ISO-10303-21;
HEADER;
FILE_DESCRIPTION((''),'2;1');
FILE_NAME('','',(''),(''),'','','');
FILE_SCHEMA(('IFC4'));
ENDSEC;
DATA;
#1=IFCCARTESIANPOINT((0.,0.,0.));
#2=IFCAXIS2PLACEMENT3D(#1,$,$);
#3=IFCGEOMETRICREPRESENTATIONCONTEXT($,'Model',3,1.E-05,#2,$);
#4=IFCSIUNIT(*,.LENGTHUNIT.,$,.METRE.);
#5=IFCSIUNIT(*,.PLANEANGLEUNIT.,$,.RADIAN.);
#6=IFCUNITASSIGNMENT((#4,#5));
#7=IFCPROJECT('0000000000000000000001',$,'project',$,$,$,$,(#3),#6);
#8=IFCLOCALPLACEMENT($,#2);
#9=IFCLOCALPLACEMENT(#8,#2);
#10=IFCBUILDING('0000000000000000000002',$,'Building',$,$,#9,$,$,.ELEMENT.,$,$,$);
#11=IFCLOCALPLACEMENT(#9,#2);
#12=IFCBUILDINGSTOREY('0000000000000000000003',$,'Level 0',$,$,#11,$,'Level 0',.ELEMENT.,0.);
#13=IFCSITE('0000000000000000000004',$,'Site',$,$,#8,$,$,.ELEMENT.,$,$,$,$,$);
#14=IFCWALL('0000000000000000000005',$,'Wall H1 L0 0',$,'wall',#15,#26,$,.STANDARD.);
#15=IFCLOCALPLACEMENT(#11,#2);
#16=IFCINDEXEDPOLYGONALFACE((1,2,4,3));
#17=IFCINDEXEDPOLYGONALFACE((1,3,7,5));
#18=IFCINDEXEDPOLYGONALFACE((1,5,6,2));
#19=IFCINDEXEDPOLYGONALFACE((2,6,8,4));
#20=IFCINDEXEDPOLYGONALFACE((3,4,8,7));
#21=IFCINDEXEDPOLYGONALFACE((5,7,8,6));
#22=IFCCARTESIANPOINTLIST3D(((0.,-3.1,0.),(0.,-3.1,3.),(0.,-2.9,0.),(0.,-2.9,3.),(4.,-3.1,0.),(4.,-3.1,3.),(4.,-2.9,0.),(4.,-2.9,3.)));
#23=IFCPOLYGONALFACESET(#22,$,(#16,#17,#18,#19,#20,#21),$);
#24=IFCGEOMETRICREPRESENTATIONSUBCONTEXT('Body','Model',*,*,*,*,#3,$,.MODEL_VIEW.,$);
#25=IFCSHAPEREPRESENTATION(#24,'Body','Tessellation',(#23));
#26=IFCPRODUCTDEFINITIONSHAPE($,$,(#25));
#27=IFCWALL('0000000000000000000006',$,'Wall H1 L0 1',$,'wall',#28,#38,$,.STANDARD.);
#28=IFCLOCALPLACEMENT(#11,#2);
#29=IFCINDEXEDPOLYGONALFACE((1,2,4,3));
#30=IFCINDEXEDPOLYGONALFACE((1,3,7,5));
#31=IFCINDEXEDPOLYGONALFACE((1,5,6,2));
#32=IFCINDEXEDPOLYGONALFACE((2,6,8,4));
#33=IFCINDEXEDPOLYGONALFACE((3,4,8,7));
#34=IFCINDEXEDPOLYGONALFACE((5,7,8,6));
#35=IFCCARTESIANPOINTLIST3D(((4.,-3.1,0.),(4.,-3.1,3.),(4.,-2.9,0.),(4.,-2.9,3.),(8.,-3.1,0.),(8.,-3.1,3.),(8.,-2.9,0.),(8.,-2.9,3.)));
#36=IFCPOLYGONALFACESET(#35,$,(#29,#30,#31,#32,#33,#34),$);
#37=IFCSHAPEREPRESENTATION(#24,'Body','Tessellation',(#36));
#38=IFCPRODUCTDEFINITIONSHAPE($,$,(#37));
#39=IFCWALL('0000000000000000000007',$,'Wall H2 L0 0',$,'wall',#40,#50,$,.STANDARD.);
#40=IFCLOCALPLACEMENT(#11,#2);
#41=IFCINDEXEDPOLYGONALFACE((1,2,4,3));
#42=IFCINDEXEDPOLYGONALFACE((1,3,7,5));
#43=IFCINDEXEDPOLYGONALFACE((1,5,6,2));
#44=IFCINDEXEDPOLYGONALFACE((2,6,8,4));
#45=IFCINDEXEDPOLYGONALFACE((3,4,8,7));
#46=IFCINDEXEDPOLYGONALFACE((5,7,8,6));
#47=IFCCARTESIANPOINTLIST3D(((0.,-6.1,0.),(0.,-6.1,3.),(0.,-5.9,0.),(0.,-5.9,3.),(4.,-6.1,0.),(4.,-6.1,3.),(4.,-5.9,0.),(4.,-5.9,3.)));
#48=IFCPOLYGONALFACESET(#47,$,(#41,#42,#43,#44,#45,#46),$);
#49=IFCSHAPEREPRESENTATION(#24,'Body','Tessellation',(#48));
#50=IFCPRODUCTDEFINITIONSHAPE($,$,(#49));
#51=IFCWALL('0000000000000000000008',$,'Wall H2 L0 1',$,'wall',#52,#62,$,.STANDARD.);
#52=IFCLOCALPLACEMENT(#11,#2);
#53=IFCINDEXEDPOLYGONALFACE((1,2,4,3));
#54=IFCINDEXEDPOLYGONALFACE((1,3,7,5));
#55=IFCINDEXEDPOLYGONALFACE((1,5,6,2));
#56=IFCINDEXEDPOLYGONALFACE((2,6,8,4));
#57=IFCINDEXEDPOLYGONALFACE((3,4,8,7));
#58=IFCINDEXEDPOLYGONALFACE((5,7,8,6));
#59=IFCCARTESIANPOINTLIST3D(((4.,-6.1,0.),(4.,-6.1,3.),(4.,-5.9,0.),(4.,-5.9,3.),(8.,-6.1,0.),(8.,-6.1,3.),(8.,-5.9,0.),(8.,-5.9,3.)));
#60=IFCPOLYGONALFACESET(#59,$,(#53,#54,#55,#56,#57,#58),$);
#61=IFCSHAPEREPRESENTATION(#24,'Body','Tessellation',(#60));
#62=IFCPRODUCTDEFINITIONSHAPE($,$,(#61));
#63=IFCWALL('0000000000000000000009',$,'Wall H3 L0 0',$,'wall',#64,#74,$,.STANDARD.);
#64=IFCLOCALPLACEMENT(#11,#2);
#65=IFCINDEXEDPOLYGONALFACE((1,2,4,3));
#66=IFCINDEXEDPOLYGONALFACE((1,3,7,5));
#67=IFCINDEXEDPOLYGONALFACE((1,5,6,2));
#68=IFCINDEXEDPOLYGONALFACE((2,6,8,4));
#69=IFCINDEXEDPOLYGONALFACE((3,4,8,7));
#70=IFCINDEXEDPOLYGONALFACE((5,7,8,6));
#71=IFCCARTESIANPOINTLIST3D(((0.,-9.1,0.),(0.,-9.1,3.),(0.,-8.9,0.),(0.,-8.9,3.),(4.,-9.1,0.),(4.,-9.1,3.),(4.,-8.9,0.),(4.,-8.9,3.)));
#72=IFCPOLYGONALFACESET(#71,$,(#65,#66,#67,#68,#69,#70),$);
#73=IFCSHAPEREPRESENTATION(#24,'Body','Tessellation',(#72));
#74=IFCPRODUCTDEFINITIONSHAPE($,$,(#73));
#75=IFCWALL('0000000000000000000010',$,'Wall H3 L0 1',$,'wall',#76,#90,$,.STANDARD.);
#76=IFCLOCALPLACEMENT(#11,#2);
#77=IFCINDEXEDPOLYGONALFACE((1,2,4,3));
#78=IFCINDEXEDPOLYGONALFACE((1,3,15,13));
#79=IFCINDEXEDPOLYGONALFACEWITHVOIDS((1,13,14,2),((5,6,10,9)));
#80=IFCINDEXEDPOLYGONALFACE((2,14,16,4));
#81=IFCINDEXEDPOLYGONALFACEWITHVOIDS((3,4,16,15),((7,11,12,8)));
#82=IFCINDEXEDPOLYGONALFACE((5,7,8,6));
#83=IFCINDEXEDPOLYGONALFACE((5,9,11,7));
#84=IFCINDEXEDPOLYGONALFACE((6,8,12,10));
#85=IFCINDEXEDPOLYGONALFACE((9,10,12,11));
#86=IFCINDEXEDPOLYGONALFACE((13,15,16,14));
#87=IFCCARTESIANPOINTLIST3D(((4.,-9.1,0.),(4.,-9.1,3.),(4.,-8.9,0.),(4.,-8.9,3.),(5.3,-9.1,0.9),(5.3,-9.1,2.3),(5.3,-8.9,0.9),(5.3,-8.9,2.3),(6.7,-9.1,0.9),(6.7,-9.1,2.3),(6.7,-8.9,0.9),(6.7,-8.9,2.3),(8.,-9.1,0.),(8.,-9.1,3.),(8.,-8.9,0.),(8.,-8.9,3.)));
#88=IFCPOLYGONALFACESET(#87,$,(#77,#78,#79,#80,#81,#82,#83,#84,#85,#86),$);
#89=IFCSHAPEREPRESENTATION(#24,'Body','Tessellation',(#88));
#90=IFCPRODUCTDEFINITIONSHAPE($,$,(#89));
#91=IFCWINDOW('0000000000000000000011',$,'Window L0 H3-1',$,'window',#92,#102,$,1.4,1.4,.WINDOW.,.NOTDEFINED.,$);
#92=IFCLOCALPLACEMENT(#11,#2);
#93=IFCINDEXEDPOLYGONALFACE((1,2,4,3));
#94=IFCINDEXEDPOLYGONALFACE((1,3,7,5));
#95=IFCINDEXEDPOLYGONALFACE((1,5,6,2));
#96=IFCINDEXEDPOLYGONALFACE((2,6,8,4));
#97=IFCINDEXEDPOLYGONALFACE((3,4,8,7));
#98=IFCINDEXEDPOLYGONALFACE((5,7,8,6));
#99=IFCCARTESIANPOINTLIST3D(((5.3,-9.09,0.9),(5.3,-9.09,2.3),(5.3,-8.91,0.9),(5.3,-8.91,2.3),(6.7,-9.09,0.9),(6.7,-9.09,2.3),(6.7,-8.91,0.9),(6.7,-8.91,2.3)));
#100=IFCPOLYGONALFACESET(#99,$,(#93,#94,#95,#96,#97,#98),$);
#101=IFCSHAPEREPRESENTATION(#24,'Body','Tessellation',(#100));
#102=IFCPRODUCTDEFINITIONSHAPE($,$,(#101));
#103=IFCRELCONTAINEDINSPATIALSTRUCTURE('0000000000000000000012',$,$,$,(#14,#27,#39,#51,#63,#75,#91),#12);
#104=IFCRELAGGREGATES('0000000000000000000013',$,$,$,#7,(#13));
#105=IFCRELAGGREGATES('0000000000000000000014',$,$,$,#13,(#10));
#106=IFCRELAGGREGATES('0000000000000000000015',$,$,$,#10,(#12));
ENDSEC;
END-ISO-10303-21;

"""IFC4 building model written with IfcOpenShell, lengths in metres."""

from ifc_helpers import new_model, si_unit, frame, frame_2d, origin, origin_2d, place, context, subcontext, project, spatial, rectangle, extrude, element, fill, save


model = new_model("IFC4")

# Units and contexts
model_context = context("Model", 3, precision=1e-05, world=origin())
body_context = subcontext(model_context, "Body", "Model", "MODEL_VIEW")
ifc_project = project(units=[si_unit("LENGTHUNIT", "METRE"), si_unit("PLANEANGLEUNIT", "RADIAN")], contexts=[model_context])

# Site, building, storey
site_placement = place(None, origin())
site = spatial("IfcSite", under=ifc_project, at=site_placement, Name="Site", CompositionType="ELEMENT")
building_placement = place(site_placement, origin())
building = spatial("IfcBuilding", under=site, at=building_placement, Name="Building", CompositionType="ELEMENT")
storey_placement = place(building_placement, origin())
storey = spatial("IfcBuildingStorey", under=building, at=storey_placement, Name="Level 0", LongName="Level 0", CompositionType="ELEMENT", Elevation=0.0)

# Walls
for number, where, z_axis, x_axis, name in (
    (1, (0.0, -3.0, 0.0), (0.0, 0.0, 1.0), (1.0, 0.0, 0.0), "Wall H1 L0 0"),
    (2, (4.0, -3.0, 0.0), (0.0, 0.0, 1.0), (1.0, 0.0, 0.0), "Wall H1 L0 1"),
    (3, (0.0, -6.0, 0.0), (0.0, 0.0, 1.0), (1.0, 0.0, 0.0), "Wall H2 L0 0"),
    (4, (4.0, -6.0, 0.0), (0.0, 0.0, 1.0), (1.0, 0.0, 0.0), "Wall H2 L0 1"),
    (5, (0.0, -9.0, 0.0), (0.0, 0.0, 1.0), (1.0, 0.0, 0.0), "Wall H3 L0 0"),
):
    element("IfcWall", number, at=place(storey_placement, frame(where, z_axis=z_axis, x_axis=x_axis)), inside=storey, Name=name, ObjectType="wall", PredefinedType="STANDARD", context=body_context, shape_type="SweptSolid", body=[
        extrude(rectangle(XDim=4.0, YDim=0.2, at=frame_2d((2.0, 0.0))), origin(), (0.0, 0.0, 1.0), 3.0),
    ])

# Wall, opening, window
wall_1_placement = place(storey_placement, frame((4.0, -9.0, 0.0), z_axis=(0.0, 0.0, 1.0), x_axis=(1.0, 0.0, 0.0)))
wall_1 = element("IfcWall", 6, at=wall_1_placement, inside=storey, Name="Wall H3 L0 1", ObjectType="wall", PredefinedType="STANDARD", context=body_context, shape_type="SweptSolid", body=[
    extrude(rectangle(XDim=4.0, YDim=0.2, at=frame_2d((2.0, 0.0))), origin(), (0.0, 0.0, 1.0), 3.0),
])
opening_1_placement = place(storey_placement, frame((6.0, -9.0, 0.9), z_axis=(0.0, 0.0, 1.0), x_axis=(1.0, 0.0, 0.0)))
opening_1 = element("IfcOpeningElement", 7, at=opening_1_placement, cuts=wall_1, ObjectType="Opening", PredefinedType="OPENING", context=body_context, shape_type="SweptSolid", body=[
    extrude(rectangle(XDim=1.4, YDim=0.22, at=origin_2d()), origin(), (0.0, 0.0, 1.0), 1.4),
])
window_1_placement = place(storey_placement, frame((6.0, -9.0, 0.9), z_axis=(0.0, 0.0, 1.0), x_axis=(1.0, 0.0, 0.0)))
window_1 = element("IfcWindow", 8, at=window_1_placement, inside=storey, Name="Window L0 H3-1", ObjectType="window", OverallHeight=1.4, OverallWidth=1.4, PartitioningType="NOTDEFINED", PredefinedType="WINDOW", context=body_context, shape_type="SweptSolid", body=[
    extrude(rectangle(XDim=1.4, YDim=0.18, at=origin_2d()), origin(), (0.0, 0.0, 1.0), 1.4),
])
fill(opening_1, window_1)

save(model, "model.ifc")
